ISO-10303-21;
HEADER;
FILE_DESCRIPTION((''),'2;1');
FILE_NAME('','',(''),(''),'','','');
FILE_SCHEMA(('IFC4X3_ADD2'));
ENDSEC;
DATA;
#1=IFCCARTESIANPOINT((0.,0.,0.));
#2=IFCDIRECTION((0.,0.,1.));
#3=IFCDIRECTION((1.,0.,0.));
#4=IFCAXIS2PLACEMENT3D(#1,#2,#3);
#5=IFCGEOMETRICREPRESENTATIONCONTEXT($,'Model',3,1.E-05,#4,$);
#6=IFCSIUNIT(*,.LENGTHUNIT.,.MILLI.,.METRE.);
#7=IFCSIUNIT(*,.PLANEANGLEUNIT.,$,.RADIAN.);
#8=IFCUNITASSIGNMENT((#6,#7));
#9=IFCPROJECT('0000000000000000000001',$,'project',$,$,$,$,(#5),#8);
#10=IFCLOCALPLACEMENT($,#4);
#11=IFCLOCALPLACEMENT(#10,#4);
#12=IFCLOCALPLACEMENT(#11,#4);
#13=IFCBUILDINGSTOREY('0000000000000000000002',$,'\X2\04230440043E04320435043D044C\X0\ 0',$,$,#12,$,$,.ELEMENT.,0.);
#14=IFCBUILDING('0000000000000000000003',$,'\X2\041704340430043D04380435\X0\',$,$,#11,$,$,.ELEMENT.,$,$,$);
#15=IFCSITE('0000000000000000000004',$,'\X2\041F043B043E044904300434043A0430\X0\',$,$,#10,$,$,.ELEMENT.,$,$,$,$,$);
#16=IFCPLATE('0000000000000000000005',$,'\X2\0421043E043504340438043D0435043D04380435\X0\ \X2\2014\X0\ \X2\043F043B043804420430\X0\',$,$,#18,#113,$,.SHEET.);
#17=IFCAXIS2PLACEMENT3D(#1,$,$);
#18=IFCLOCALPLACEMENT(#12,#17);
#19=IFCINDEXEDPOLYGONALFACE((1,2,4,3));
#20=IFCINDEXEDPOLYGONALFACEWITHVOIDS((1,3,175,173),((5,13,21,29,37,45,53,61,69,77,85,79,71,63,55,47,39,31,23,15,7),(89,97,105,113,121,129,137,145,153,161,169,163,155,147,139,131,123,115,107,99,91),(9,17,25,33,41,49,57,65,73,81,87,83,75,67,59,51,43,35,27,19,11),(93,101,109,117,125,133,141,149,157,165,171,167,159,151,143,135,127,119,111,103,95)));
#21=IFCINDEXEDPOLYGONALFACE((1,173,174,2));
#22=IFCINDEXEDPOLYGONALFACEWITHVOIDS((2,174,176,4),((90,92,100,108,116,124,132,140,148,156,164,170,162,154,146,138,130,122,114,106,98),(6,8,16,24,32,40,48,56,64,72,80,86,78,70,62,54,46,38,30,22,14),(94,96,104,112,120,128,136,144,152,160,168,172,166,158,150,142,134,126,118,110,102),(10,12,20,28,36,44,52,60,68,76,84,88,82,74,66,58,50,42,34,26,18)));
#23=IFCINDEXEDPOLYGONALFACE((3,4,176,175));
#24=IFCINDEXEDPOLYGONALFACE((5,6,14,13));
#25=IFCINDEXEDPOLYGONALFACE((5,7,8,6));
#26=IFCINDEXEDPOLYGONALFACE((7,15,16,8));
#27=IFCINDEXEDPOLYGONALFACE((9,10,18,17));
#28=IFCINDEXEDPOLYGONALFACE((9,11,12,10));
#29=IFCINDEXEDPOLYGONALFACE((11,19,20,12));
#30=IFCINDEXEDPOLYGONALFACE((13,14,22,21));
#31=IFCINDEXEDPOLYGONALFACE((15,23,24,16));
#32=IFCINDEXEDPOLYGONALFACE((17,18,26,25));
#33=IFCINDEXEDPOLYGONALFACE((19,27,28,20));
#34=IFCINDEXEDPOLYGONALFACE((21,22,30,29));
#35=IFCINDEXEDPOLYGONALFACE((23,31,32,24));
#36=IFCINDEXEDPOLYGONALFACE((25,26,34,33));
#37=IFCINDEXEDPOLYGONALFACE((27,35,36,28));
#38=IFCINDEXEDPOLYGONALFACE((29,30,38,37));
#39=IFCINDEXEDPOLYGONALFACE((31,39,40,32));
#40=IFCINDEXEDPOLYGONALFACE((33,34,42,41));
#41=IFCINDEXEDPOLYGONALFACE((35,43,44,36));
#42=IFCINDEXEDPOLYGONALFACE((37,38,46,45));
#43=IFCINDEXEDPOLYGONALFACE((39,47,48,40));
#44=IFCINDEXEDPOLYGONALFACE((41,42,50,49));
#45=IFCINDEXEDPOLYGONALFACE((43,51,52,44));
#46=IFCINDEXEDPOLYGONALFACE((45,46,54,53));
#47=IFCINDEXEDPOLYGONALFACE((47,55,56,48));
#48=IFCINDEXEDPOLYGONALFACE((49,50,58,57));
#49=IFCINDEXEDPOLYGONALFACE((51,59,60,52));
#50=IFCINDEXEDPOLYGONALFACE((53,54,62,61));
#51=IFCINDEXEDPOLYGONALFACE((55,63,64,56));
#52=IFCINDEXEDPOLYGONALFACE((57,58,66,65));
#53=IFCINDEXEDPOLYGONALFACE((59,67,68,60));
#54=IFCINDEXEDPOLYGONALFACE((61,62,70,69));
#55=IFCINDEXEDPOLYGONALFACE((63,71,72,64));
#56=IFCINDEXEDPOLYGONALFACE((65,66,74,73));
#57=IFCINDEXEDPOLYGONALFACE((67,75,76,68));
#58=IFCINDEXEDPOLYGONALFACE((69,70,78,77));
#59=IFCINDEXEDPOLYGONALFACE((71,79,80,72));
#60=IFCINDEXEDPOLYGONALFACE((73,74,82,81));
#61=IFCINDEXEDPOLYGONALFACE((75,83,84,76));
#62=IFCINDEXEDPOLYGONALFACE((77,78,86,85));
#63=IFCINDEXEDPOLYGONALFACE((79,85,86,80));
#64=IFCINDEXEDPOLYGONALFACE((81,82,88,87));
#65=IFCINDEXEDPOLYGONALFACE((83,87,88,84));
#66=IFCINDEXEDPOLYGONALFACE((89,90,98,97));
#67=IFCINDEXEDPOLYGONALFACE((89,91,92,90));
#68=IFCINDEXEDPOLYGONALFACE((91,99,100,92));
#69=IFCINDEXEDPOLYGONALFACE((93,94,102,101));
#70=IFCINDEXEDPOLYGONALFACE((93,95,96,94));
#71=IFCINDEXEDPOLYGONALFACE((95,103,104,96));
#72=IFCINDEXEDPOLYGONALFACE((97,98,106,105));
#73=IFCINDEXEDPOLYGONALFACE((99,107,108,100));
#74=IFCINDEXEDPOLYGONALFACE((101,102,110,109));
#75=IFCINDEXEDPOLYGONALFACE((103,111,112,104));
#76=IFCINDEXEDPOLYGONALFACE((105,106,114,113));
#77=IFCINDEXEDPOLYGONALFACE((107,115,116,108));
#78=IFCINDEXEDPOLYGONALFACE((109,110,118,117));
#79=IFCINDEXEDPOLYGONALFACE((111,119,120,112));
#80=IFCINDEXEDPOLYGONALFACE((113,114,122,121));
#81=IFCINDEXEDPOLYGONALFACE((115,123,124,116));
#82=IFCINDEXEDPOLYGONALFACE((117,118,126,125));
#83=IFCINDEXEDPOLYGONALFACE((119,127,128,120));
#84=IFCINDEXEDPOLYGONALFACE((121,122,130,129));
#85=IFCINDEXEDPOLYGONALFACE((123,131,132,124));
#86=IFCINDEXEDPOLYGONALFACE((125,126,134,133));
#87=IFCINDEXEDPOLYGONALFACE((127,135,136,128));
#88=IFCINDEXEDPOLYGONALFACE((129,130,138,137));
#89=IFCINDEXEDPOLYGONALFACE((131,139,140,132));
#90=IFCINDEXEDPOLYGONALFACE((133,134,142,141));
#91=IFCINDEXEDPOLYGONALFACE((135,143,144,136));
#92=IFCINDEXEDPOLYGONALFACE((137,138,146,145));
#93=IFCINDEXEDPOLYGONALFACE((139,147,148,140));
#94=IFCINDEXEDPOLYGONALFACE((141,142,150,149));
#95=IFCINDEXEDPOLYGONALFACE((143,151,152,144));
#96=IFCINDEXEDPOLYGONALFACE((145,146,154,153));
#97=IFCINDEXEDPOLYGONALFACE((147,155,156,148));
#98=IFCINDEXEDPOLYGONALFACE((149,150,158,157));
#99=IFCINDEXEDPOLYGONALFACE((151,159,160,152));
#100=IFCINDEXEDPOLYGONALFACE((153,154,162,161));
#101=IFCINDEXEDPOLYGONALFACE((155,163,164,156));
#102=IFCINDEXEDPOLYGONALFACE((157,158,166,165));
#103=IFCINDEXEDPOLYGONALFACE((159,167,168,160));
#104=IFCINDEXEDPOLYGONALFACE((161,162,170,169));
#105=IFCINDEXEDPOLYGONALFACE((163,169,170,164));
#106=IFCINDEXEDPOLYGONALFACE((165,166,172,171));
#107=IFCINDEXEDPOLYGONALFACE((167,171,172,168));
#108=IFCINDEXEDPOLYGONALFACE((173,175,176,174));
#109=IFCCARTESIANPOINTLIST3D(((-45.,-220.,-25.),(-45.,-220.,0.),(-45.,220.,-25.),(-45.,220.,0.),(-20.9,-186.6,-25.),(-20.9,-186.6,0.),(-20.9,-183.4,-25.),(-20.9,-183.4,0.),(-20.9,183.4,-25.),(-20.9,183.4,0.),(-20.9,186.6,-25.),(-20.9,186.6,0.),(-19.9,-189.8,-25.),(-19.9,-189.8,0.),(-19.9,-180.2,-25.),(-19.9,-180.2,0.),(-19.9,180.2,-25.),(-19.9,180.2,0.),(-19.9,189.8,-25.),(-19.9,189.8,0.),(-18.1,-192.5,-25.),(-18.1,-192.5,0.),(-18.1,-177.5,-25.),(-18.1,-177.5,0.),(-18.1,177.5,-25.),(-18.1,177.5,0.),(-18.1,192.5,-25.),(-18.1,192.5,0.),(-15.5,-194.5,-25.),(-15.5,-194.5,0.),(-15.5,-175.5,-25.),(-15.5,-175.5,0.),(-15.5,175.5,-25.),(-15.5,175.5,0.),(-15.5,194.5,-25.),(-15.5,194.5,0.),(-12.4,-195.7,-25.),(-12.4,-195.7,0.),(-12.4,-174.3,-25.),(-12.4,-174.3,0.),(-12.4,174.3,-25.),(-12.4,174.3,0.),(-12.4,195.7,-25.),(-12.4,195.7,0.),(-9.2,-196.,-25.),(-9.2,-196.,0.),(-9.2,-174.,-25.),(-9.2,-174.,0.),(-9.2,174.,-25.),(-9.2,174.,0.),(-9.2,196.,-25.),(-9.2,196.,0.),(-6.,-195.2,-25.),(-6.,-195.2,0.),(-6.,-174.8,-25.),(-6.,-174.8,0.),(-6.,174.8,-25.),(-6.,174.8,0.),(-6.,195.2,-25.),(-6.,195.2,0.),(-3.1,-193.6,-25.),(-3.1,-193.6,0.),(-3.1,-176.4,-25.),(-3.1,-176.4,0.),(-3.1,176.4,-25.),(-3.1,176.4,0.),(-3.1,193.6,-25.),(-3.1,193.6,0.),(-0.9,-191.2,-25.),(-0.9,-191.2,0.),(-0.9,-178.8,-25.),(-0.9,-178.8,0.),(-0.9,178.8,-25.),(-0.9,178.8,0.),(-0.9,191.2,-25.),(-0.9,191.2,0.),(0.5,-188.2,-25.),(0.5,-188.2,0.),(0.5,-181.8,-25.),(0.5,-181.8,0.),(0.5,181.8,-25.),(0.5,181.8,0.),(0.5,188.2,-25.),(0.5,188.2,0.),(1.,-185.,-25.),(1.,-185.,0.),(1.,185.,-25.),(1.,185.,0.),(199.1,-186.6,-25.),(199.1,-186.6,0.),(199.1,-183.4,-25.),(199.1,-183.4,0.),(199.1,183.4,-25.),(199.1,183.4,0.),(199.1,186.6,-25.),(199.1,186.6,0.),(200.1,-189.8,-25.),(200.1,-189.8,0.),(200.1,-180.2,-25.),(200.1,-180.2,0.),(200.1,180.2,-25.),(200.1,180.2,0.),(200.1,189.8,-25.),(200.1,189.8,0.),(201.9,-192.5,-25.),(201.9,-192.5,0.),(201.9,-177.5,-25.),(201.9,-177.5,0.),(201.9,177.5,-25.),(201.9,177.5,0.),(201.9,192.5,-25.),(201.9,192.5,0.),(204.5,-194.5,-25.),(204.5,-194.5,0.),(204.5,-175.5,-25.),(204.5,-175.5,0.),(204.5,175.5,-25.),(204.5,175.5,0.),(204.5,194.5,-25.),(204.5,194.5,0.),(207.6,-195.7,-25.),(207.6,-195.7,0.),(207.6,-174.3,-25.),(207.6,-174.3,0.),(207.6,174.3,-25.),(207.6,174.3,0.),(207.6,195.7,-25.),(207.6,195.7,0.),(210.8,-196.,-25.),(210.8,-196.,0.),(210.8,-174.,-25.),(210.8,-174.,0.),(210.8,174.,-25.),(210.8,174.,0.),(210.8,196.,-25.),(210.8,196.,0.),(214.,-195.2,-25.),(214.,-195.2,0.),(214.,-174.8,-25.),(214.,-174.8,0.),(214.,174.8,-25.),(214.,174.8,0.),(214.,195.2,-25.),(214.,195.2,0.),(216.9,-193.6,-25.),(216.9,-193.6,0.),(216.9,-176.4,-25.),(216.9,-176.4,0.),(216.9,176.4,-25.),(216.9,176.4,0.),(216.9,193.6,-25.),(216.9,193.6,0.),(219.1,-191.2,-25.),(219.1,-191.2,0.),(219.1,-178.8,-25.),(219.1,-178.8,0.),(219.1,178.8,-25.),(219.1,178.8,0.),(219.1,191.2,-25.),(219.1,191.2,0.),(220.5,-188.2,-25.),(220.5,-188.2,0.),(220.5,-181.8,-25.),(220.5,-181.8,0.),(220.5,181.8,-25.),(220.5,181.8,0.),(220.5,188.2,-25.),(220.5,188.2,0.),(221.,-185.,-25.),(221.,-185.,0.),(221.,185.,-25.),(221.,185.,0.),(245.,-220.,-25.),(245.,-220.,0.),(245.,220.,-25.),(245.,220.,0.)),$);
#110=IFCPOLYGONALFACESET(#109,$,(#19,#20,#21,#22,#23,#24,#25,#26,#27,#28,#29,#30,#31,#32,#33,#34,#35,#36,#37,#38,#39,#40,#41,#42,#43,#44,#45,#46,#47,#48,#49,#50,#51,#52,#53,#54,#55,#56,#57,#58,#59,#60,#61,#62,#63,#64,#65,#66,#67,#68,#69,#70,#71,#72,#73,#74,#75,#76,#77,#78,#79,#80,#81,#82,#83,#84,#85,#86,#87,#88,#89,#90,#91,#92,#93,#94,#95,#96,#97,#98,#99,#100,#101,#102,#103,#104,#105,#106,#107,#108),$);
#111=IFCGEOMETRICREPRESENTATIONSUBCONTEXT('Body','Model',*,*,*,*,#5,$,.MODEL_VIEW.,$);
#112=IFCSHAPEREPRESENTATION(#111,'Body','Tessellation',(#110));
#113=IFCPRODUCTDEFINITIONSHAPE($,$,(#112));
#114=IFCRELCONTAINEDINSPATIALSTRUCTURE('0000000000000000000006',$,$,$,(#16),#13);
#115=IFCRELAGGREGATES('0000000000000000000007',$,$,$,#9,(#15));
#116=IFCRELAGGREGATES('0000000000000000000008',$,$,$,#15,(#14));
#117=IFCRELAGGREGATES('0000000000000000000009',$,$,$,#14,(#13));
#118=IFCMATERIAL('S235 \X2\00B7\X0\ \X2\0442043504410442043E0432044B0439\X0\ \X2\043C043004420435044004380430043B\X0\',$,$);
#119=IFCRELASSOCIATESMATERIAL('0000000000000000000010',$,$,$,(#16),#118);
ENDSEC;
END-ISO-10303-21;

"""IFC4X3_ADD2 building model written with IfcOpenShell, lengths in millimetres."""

from ifc_helpers import new_model, si_unit, frame, origin_with_axes, place, context, subcontext, project, spatial, polyline, circle, outline, extrude, material, element, save


model = new_model("IFC4X3_ADD2")

# Units and contexts
model_context = context("Model", 3, precision=1e-05, world=origin_with_axes())
body_context = subcontext(model_context, "Body", "Model", "MODEL_VIEW")
ifc_project = project(units=[si_unit("LENGTHUNIT", "METRE", prefix="MILLI"), si_unit("PLANEANGLEUNIT", "RADIAN")], contexts=[model_context])

# Site, building, storey
site_placement = place(None, origin_with_axes())
site = spatial("IfcSite", under=ifc_project, at=site_placement, Name="Площадка", CompositionType="ELEMENT")
building_placement = place(site_placement, origin_with_axes())
building = spatial("IfcBuilding", under=site, at=building_placement, Name="Здание", CompositionType="ELEMENT")
storey_placement = place(building_placement, origin_with_axes())
storey = spatial("IfcBuildingStorey", under=building, at=storey_placement, Name="Уровень 0", CompositionType="ELEMENT", Elevation=0.0)

# Shared definitions
ifc_material = material(Name="S235 · тестовый материал")

# Plate, openings
plate_1_placement = place(storey_placement, frame((-45.0, -220.0, -25.0), z_axis=(0.0, 0.0, 1.0), x_axis=(1.0, 0.0, 0.0)))
plate_1 = element("IfcPlate", 1, at=plate_1_placement, inside=storey, material=ifc_material, Name="Соединение — плита", PredefinedType="SHEET", context=body_context, shape_type="SweptSolid", body=[
    extrude(outline(polyline([(0.0, 0.0), (290.0, 0.0), (290.0, 440.0), (0.0, 440.0), (0.0, 0.0)])), origin_with_axes(), (0.0, 0.0, 1.0), 25.0),
])
opening_1_placement = place(plate_1_placement, frame((35.0, 35.0, -1.0), z_axis=(0.0, 0.0, 1.0), x_axis=(1.0, 0.0, 0.0)))
element("IfcOpeningElement", 2, at=opening_1_placement, cuts=plate_1, PredefinedType="OPENING", context=body_context, shape_type="SweptSolid", body=[
    extrude(circle(Radius=11.0), origin_with_axes(), (0.0, 0.0, 1.0), 27.0),
])
opening_2_placement = place(plate_1_placement, frame((255.0, 35.0, -1.0), z_axis=(0.0, 0.0, 1.0), x_axis=(1.0, 0.0, 0.0)))
element("IfcOpeningElement", 3, at=opening_2_placement, cuts=plate_1, PredefinedType="OPENING", context=body_context, shape_type="SweptSolid", body=[
    extrude(circle(Radius=11.0), origin_with_axes(), (0.0, 0.0, 1.0), 27.0),
])
opening_3_placement = place(plate_1_placement, frame((35.0, 405.0, -1.0), z_axis=(0.0, 0.0, 1.0), x_axis=(1.0, 0.0, 0.0)))
element("IfcOpeningElement", 4, at=opening_3_placement, cuts=plate_1, PredefinedType="OPENING", context=body_context, shape_type="SweptSolid", body=[
    extrude(circle(Radius=11.0), origin_with_axes(), (0.0, 0.0, 1.0), 27.0),
])
opening_4_placement = place(plate_1_placement, frame((255.0, 405.0, -1.0), z_axis=(0.0, 0.0, 1.0), x_axis=(1.0, 0.0, 0.0)))
element("IfcOpeningElement", 5, at=opening_4_placement, cuts=plate_1, PredefinedType="OPENING", context=body_context, shape_type="SweptSolid", body=[
    extrude(circle(Radius=11.0), origin_with_axes(), (0.0, 0.0, 1.0), 27.0),
])

save(model, "model.ifc")
